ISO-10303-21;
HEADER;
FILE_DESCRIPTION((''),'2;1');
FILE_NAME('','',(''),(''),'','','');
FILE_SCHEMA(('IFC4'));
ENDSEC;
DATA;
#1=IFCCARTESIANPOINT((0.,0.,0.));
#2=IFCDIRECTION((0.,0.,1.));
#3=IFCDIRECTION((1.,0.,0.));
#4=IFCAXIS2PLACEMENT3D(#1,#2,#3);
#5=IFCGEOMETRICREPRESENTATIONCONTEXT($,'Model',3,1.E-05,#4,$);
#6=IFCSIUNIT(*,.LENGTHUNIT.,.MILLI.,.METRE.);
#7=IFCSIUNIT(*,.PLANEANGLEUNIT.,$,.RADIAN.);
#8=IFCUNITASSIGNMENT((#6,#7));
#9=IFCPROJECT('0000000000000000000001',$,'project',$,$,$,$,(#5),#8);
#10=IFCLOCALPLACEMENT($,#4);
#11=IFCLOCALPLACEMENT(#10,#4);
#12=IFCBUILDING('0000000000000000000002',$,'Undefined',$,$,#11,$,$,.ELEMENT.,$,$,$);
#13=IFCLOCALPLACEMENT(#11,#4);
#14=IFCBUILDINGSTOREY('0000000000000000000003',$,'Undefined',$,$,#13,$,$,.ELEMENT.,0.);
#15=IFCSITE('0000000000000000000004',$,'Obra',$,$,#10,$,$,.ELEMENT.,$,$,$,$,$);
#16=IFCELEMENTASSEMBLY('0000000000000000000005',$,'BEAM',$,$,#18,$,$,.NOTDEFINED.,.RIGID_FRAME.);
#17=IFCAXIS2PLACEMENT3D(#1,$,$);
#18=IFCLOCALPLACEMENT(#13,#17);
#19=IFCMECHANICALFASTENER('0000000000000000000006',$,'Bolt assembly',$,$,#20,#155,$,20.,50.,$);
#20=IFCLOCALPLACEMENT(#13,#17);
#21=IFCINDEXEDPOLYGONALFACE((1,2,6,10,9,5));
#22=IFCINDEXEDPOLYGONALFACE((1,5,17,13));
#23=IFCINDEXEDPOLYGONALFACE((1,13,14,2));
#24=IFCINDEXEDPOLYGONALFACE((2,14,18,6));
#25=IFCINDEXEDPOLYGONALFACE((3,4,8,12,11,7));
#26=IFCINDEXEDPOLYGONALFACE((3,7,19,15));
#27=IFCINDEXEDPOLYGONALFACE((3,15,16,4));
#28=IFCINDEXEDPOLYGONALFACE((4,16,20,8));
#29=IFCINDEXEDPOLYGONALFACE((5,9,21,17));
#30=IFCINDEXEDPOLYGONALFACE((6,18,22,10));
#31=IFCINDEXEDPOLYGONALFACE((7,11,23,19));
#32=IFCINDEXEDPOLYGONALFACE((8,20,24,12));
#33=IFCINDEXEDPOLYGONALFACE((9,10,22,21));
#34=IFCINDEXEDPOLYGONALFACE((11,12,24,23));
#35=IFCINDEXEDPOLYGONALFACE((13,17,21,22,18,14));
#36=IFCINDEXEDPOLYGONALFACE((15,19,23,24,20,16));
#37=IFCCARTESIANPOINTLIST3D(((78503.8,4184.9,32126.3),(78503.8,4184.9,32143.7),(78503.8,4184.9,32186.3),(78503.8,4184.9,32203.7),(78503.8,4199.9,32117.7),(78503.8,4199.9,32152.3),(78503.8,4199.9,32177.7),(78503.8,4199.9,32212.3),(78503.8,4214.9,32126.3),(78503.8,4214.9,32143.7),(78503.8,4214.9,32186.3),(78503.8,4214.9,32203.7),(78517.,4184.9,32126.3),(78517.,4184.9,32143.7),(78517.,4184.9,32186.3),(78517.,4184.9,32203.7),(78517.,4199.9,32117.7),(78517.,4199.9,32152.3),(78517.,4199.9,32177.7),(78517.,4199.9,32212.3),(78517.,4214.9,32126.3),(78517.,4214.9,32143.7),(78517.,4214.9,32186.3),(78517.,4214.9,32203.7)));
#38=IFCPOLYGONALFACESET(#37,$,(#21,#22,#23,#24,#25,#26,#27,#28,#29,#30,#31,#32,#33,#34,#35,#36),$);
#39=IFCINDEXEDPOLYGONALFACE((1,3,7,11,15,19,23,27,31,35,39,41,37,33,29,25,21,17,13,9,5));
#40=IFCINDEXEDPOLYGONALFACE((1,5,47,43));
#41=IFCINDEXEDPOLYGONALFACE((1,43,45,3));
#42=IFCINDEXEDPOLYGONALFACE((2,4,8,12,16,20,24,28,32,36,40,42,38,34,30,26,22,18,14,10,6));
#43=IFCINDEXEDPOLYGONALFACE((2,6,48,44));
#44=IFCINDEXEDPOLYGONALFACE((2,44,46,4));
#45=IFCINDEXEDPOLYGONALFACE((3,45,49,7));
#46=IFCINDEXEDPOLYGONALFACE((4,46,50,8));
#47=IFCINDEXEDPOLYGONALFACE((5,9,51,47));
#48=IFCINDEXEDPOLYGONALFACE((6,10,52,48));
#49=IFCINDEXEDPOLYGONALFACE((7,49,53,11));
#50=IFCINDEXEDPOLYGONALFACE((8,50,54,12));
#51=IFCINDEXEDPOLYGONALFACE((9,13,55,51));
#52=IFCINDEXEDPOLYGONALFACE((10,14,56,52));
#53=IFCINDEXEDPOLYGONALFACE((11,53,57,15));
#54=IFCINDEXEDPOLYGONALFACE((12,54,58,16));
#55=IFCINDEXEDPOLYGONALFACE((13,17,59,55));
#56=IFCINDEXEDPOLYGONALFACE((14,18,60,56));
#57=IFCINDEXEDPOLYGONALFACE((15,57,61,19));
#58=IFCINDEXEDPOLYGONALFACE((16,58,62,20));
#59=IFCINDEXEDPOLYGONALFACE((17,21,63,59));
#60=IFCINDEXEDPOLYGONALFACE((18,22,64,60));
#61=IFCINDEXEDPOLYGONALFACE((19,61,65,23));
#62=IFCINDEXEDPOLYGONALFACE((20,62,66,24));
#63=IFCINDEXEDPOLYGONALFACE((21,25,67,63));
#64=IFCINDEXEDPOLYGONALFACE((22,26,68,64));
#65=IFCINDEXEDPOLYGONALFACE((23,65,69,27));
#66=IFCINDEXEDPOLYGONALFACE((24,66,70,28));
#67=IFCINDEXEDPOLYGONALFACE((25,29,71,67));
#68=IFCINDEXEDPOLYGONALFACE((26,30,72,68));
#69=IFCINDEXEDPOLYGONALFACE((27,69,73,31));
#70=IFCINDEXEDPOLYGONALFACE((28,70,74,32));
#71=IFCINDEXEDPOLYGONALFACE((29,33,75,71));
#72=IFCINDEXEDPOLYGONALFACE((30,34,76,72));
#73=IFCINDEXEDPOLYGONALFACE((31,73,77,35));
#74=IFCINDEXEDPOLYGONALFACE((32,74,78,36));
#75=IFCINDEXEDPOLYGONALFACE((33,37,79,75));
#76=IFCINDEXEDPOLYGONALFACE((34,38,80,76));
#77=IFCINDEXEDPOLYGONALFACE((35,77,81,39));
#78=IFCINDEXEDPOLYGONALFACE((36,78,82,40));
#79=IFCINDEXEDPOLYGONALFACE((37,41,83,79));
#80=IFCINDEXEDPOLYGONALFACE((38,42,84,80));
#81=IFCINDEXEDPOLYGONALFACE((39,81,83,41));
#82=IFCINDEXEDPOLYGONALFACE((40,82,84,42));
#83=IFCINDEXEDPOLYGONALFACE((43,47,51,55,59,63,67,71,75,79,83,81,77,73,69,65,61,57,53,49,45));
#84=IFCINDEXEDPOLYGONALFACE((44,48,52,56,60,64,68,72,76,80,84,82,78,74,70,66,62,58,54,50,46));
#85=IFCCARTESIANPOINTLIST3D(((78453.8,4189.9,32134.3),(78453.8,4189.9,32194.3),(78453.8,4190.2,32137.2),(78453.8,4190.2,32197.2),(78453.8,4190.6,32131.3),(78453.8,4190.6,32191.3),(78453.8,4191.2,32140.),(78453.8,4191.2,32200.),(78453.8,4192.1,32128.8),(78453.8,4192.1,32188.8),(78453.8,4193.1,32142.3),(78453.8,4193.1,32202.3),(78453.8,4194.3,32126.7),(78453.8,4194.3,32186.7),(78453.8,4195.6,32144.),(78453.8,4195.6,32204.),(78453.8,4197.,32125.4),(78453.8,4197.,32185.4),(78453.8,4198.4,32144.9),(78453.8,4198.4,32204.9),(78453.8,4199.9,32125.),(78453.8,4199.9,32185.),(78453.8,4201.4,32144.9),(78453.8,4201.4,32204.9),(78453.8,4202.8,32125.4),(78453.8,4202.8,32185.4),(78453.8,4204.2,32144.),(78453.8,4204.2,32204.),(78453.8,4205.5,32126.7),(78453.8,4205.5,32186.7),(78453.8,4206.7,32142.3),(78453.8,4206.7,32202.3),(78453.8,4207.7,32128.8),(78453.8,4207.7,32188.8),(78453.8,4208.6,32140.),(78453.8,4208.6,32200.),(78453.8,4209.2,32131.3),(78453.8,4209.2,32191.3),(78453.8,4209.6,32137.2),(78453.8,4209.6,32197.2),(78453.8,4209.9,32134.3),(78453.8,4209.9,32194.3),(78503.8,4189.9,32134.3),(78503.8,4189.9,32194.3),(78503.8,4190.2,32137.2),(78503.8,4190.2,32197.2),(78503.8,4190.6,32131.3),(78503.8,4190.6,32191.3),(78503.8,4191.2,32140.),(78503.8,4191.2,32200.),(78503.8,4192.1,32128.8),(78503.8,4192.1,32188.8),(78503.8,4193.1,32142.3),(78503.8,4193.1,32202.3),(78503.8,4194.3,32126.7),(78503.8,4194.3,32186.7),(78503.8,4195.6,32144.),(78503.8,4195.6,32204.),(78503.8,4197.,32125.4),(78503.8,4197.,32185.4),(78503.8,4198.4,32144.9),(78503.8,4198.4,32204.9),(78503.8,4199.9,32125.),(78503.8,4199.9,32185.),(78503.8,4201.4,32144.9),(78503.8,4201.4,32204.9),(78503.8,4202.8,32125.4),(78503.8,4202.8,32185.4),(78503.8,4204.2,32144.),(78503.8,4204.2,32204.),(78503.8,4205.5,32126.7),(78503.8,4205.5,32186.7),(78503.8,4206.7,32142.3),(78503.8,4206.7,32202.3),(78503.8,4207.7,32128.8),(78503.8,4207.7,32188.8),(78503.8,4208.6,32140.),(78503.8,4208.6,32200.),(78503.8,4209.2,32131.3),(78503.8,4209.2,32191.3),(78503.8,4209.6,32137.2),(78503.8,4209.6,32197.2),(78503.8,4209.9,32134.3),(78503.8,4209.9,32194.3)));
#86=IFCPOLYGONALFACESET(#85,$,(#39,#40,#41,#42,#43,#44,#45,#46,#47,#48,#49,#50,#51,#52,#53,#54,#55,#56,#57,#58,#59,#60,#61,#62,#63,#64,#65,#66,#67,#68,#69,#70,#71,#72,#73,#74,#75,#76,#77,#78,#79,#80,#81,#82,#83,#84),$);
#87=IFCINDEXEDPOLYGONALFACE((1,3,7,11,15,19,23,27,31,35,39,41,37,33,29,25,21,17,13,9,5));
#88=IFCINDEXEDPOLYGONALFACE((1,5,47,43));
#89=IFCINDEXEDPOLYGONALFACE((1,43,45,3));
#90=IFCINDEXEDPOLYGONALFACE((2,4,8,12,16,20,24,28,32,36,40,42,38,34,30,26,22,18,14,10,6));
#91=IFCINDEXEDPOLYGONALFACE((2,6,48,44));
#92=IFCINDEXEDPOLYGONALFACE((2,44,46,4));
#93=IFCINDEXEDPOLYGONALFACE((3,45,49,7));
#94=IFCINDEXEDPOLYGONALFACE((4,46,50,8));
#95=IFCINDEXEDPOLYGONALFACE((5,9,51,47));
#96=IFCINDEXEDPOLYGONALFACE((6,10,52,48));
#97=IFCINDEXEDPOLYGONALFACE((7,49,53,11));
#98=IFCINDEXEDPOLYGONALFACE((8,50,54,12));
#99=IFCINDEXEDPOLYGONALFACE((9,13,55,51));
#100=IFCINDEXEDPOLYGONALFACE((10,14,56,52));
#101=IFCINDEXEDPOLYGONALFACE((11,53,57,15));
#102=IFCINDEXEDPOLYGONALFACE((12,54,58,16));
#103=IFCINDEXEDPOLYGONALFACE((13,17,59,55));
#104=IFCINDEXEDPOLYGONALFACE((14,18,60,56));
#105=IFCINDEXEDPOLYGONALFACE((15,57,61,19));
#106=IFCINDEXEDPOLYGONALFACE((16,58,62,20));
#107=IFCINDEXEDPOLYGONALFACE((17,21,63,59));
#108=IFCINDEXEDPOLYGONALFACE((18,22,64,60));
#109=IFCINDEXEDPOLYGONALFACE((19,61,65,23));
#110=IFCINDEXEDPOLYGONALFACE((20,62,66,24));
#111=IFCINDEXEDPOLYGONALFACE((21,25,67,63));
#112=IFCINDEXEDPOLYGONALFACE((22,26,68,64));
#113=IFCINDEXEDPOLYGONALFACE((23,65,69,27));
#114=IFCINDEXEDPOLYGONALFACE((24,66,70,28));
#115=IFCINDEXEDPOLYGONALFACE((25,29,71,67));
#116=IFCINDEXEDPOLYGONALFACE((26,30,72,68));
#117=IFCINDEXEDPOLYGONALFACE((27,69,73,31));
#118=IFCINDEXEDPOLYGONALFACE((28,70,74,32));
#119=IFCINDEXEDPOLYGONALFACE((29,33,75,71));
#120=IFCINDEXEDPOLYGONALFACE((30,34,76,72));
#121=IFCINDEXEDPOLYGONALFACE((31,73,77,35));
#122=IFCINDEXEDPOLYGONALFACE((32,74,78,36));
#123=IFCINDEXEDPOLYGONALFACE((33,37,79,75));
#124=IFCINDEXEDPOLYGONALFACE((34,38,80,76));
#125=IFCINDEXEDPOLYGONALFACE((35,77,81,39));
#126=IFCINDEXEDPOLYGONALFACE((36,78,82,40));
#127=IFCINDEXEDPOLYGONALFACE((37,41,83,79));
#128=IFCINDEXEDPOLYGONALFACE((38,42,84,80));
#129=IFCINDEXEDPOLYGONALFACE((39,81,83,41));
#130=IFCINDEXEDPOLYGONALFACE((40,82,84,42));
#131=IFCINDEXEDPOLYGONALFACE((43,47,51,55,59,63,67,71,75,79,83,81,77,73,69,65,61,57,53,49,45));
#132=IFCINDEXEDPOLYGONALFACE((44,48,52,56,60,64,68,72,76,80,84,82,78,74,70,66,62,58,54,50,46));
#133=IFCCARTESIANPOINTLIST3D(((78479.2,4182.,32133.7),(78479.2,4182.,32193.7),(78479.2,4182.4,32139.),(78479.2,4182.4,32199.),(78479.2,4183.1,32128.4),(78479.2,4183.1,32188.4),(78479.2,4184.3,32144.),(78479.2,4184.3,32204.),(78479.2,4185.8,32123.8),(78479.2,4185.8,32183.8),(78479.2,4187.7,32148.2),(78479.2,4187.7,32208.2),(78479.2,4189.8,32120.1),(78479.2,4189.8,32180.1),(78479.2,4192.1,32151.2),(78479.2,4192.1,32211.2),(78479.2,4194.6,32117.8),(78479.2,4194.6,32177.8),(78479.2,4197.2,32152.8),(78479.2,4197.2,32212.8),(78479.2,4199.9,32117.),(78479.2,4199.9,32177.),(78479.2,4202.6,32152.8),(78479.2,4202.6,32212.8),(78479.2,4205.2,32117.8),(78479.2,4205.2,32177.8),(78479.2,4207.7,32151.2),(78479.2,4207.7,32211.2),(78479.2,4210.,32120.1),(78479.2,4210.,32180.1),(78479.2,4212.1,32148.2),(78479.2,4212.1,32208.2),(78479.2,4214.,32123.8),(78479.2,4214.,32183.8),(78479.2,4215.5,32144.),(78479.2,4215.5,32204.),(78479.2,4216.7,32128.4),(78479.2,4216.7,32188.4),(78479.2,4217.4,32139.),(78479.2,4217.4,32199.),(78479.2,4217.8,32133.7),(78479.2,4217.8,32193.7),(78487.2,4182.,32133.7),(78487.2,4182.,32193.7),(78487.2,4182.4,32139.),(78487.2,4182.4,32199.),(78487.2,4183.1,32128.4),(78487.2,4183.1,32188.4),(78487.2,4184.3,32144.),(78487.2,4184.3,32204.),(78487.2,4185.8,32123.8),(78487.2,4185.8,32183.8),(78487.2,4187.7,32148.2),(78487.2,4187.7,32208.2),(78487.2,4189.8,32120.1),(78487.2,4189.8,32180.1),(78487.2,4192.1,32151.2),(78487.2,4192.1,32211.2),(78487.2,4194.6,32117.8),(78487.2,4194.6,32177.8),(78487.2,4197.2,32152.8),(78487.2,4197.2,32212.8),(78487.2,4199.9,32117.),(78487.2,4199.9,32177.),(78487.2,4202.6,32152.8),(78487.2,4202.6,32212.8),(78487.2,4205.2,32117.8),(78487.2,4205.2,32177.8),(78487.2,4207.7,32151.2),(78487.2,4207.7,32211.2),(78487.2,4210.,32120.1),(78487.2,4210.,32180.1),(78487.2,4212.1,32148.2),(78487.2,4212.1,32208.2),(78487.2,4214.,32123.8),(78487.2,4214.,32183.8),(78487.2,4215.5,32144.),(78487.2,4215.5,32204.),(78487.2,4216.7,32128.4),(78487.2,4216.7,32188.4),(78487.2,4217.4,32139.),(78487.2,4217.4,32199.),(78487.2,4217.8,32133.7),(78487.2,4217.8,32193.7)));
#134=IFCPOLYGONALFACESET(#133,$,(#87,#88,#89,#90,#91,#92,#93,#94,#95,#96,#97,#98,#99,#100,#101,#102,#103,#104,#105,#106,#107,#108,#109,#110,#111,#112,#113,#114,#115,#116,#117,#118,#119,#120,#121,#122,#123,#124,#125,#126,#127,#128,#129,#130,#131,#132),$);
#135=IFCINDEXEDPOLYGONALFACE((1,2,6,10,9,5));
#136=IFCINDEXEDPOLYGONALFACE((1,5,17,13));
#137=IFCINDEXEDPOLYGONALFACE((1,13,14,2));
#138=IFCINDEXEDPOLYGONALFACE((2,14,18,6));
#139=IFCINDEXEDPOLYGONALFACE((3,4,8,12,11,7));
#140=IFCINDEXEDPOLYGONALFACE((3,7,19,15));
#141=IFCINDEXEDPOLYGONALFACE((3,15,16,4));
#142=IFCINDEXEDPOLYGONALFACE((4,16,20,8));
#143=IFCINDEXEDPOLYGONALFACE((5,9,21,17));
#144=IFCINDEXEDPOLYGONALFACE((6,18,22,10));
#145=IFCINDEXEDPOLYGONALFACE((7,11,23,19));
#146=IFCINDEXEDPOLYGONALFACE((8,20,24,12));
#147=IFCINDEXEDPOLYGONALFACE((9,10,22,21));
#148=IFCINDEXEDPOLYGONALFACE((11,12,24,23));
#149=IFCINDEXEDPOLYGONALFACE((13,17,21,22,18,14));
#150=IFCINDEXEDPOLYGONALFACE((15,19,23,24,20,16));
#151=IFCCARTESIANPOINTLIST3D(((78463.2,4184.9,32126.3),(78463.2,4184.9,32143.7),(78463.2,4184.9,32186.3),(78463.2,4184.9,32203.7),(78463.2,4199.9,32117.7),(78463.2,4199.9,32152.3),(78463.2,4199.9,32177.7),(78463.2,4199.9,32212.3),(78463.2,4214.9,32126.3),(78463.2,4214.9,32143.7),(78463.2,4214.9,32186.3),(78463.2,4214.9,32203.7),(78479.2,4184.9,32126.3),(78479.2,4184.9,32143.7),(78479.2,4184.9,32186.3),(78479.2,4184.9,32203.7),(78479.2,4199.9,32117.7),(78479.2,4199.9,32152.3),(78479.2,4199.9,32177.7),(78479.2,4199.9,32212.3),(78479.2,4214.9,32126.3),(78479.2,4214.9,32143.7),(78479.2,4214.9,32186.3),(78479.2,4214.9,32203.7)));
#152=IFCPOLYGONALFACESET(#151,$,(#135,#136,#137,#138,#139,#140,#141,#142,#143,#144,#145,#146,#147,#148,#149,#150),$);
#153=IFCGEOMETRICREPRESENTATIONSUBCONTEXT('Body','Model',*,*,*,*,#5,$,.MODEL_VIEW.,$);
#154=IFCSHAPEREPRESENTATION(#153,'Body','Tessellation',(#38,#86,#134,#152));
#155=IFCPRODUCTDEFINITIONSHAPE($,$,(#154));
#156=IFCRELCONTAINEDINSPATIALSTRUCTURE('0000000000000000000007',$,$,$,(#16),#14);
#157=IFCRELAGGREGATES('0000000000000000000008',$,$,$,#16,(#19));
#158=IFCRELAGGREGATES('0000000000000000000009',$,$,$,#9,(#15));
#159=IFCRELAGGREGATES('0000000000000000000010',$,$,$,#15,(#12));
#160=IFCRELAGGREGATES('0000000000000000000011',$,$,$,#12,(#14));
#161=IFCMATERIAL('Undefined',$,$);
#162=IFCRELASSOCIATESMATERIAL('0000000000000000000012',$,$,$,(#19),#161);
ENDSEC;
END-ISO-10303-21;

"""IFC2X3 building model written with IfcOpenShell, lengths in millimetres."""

from ifc_helpers import new_model, si_unit, frame, origin_with_axes, origin_2d_with_axis, place, context, subcontext, project, spatial, polyline, circle, outline, extrude, source, transform, mapped, material, element, aggregate, save


model = new_model("IFC2X3")

# Units and contexts
model_context = context("Model", 3, precision=1e-05, world=origin_with_axes())
body_context = subcontext(model_context, "Body", "Model", "MODEL_VIEW")
ifc_project = project(units=[si_unit("LENGTHUNIT", "METRE", prefix="MILLI"), si_unit("PLANEANGLEUNIT", "RADIAN")], contexts=[model_context])

# Site, building, storey
site_placement = place(None, origin_with_axes())
site = spatial("IfcSite", under=ifc_project, at=site_placement, Name="Obra", CompositionType="ELEMENT")
building_placement = place(site_placement, origin_with_axes())
building = spatial("IfcBuilding", under=site, at=building_placement, Name="Undefined", CompositionType="ELEMENT")
storey_placement = place(building_placement, origin_with_axes())
storey = spatial("IfcBuildingStorey", under=building, at=storey_placement, Name="Undefined", CompositionType="ELEMENT", Elevation=0.0)

# Shared definitions
ifc_material_1 = material(Name="Undefined")

# Element assembly, mechanical fastener
assembly_1_placement = place(storey_placement, origin_with_axes())
assembly_1 = element("IfcElementAssembly", 1, at=assembly_1_placement, inside=storey, Name="BEAM", AssemblyPlace="NOTDEFINED", PredefinedType="RIGID_FRAME")
shared_shape_1 = source(origin_with_axes(), body_context, "Body", "SweptSolid", [
    extrude(outline(polyline([(17.3, 0.0), (8.7, 15.0), (-8.7, 15.0), (-17.3, 0.0), (-8.7, -15.0), (8.7, -15.0), (17.3, 0.0)])), frame((0.0, -26.5, 0.0), z_axis=(0.0, 1.0, 0.0), x_axis=(1.0, 0.0, 0.0)), (0.0, 0.0, 1.0), 13.2),
    extrude(circle(Radius=10.0, at=origin_2d_with_axis()), frame((0.0, -13.3, 0.0), z_axis=(0.0, 1.0, 0.0), x_axis=(1.0, 0.0, 0.0)), (0.0, 0.0, 1.0), 50.0),
    extrude(circle(Radius=18.0, at=origin_2d_with_axis()), frame((0.0, 3.3, 0.0), z_axis=(0.0, 1.0, 0.0), x_axis=(1.0, 0.0, 0.0)), (0.0, 0.0, 1.0), 8.0),
    extrude(outline(polyline([(17.3, 0.0), (8.7, 15.0), (-8.7, 15.0), (-17.3, 0.0), (-8.7, -15.0), (8.7, -15.0), (17.3, 0.0)])), frame((0.0, 11.3, 0.0), z_axis=(0.0, 1.0, 0.0), x_axis=(1.0, 0.0, 0.0)), (0.0, 0.0, 1.0), 16.0),
])
mechanical_fastener_1_placement = place(assembly_1_placement, frame((78490.5, 4159.9, 32235.0), z_axis=(0.0, 1.0, 0.0), x_axis=(0.0, 0.0, -1.0)))
mechanical_fastener_1 = element("IfcMechanicalFastener", 2, at=mechanical_fastener_1_placement, material=ifc_material_1, Name="Bolt assembly", NominalDiameter=20.0, NominalLength=50.0, context=body_context, shape_type="MappedRepresentation", body=[
    mapped(shared_shape_1, transform((40.0, 0.0, 40.0))),
    mapped(shared_shape_1, transform((100.0, 0.0, 40.0))),
])
aggregate(assembly_1, [mechanical_fastener_1])

save(model, "model.ifc")
